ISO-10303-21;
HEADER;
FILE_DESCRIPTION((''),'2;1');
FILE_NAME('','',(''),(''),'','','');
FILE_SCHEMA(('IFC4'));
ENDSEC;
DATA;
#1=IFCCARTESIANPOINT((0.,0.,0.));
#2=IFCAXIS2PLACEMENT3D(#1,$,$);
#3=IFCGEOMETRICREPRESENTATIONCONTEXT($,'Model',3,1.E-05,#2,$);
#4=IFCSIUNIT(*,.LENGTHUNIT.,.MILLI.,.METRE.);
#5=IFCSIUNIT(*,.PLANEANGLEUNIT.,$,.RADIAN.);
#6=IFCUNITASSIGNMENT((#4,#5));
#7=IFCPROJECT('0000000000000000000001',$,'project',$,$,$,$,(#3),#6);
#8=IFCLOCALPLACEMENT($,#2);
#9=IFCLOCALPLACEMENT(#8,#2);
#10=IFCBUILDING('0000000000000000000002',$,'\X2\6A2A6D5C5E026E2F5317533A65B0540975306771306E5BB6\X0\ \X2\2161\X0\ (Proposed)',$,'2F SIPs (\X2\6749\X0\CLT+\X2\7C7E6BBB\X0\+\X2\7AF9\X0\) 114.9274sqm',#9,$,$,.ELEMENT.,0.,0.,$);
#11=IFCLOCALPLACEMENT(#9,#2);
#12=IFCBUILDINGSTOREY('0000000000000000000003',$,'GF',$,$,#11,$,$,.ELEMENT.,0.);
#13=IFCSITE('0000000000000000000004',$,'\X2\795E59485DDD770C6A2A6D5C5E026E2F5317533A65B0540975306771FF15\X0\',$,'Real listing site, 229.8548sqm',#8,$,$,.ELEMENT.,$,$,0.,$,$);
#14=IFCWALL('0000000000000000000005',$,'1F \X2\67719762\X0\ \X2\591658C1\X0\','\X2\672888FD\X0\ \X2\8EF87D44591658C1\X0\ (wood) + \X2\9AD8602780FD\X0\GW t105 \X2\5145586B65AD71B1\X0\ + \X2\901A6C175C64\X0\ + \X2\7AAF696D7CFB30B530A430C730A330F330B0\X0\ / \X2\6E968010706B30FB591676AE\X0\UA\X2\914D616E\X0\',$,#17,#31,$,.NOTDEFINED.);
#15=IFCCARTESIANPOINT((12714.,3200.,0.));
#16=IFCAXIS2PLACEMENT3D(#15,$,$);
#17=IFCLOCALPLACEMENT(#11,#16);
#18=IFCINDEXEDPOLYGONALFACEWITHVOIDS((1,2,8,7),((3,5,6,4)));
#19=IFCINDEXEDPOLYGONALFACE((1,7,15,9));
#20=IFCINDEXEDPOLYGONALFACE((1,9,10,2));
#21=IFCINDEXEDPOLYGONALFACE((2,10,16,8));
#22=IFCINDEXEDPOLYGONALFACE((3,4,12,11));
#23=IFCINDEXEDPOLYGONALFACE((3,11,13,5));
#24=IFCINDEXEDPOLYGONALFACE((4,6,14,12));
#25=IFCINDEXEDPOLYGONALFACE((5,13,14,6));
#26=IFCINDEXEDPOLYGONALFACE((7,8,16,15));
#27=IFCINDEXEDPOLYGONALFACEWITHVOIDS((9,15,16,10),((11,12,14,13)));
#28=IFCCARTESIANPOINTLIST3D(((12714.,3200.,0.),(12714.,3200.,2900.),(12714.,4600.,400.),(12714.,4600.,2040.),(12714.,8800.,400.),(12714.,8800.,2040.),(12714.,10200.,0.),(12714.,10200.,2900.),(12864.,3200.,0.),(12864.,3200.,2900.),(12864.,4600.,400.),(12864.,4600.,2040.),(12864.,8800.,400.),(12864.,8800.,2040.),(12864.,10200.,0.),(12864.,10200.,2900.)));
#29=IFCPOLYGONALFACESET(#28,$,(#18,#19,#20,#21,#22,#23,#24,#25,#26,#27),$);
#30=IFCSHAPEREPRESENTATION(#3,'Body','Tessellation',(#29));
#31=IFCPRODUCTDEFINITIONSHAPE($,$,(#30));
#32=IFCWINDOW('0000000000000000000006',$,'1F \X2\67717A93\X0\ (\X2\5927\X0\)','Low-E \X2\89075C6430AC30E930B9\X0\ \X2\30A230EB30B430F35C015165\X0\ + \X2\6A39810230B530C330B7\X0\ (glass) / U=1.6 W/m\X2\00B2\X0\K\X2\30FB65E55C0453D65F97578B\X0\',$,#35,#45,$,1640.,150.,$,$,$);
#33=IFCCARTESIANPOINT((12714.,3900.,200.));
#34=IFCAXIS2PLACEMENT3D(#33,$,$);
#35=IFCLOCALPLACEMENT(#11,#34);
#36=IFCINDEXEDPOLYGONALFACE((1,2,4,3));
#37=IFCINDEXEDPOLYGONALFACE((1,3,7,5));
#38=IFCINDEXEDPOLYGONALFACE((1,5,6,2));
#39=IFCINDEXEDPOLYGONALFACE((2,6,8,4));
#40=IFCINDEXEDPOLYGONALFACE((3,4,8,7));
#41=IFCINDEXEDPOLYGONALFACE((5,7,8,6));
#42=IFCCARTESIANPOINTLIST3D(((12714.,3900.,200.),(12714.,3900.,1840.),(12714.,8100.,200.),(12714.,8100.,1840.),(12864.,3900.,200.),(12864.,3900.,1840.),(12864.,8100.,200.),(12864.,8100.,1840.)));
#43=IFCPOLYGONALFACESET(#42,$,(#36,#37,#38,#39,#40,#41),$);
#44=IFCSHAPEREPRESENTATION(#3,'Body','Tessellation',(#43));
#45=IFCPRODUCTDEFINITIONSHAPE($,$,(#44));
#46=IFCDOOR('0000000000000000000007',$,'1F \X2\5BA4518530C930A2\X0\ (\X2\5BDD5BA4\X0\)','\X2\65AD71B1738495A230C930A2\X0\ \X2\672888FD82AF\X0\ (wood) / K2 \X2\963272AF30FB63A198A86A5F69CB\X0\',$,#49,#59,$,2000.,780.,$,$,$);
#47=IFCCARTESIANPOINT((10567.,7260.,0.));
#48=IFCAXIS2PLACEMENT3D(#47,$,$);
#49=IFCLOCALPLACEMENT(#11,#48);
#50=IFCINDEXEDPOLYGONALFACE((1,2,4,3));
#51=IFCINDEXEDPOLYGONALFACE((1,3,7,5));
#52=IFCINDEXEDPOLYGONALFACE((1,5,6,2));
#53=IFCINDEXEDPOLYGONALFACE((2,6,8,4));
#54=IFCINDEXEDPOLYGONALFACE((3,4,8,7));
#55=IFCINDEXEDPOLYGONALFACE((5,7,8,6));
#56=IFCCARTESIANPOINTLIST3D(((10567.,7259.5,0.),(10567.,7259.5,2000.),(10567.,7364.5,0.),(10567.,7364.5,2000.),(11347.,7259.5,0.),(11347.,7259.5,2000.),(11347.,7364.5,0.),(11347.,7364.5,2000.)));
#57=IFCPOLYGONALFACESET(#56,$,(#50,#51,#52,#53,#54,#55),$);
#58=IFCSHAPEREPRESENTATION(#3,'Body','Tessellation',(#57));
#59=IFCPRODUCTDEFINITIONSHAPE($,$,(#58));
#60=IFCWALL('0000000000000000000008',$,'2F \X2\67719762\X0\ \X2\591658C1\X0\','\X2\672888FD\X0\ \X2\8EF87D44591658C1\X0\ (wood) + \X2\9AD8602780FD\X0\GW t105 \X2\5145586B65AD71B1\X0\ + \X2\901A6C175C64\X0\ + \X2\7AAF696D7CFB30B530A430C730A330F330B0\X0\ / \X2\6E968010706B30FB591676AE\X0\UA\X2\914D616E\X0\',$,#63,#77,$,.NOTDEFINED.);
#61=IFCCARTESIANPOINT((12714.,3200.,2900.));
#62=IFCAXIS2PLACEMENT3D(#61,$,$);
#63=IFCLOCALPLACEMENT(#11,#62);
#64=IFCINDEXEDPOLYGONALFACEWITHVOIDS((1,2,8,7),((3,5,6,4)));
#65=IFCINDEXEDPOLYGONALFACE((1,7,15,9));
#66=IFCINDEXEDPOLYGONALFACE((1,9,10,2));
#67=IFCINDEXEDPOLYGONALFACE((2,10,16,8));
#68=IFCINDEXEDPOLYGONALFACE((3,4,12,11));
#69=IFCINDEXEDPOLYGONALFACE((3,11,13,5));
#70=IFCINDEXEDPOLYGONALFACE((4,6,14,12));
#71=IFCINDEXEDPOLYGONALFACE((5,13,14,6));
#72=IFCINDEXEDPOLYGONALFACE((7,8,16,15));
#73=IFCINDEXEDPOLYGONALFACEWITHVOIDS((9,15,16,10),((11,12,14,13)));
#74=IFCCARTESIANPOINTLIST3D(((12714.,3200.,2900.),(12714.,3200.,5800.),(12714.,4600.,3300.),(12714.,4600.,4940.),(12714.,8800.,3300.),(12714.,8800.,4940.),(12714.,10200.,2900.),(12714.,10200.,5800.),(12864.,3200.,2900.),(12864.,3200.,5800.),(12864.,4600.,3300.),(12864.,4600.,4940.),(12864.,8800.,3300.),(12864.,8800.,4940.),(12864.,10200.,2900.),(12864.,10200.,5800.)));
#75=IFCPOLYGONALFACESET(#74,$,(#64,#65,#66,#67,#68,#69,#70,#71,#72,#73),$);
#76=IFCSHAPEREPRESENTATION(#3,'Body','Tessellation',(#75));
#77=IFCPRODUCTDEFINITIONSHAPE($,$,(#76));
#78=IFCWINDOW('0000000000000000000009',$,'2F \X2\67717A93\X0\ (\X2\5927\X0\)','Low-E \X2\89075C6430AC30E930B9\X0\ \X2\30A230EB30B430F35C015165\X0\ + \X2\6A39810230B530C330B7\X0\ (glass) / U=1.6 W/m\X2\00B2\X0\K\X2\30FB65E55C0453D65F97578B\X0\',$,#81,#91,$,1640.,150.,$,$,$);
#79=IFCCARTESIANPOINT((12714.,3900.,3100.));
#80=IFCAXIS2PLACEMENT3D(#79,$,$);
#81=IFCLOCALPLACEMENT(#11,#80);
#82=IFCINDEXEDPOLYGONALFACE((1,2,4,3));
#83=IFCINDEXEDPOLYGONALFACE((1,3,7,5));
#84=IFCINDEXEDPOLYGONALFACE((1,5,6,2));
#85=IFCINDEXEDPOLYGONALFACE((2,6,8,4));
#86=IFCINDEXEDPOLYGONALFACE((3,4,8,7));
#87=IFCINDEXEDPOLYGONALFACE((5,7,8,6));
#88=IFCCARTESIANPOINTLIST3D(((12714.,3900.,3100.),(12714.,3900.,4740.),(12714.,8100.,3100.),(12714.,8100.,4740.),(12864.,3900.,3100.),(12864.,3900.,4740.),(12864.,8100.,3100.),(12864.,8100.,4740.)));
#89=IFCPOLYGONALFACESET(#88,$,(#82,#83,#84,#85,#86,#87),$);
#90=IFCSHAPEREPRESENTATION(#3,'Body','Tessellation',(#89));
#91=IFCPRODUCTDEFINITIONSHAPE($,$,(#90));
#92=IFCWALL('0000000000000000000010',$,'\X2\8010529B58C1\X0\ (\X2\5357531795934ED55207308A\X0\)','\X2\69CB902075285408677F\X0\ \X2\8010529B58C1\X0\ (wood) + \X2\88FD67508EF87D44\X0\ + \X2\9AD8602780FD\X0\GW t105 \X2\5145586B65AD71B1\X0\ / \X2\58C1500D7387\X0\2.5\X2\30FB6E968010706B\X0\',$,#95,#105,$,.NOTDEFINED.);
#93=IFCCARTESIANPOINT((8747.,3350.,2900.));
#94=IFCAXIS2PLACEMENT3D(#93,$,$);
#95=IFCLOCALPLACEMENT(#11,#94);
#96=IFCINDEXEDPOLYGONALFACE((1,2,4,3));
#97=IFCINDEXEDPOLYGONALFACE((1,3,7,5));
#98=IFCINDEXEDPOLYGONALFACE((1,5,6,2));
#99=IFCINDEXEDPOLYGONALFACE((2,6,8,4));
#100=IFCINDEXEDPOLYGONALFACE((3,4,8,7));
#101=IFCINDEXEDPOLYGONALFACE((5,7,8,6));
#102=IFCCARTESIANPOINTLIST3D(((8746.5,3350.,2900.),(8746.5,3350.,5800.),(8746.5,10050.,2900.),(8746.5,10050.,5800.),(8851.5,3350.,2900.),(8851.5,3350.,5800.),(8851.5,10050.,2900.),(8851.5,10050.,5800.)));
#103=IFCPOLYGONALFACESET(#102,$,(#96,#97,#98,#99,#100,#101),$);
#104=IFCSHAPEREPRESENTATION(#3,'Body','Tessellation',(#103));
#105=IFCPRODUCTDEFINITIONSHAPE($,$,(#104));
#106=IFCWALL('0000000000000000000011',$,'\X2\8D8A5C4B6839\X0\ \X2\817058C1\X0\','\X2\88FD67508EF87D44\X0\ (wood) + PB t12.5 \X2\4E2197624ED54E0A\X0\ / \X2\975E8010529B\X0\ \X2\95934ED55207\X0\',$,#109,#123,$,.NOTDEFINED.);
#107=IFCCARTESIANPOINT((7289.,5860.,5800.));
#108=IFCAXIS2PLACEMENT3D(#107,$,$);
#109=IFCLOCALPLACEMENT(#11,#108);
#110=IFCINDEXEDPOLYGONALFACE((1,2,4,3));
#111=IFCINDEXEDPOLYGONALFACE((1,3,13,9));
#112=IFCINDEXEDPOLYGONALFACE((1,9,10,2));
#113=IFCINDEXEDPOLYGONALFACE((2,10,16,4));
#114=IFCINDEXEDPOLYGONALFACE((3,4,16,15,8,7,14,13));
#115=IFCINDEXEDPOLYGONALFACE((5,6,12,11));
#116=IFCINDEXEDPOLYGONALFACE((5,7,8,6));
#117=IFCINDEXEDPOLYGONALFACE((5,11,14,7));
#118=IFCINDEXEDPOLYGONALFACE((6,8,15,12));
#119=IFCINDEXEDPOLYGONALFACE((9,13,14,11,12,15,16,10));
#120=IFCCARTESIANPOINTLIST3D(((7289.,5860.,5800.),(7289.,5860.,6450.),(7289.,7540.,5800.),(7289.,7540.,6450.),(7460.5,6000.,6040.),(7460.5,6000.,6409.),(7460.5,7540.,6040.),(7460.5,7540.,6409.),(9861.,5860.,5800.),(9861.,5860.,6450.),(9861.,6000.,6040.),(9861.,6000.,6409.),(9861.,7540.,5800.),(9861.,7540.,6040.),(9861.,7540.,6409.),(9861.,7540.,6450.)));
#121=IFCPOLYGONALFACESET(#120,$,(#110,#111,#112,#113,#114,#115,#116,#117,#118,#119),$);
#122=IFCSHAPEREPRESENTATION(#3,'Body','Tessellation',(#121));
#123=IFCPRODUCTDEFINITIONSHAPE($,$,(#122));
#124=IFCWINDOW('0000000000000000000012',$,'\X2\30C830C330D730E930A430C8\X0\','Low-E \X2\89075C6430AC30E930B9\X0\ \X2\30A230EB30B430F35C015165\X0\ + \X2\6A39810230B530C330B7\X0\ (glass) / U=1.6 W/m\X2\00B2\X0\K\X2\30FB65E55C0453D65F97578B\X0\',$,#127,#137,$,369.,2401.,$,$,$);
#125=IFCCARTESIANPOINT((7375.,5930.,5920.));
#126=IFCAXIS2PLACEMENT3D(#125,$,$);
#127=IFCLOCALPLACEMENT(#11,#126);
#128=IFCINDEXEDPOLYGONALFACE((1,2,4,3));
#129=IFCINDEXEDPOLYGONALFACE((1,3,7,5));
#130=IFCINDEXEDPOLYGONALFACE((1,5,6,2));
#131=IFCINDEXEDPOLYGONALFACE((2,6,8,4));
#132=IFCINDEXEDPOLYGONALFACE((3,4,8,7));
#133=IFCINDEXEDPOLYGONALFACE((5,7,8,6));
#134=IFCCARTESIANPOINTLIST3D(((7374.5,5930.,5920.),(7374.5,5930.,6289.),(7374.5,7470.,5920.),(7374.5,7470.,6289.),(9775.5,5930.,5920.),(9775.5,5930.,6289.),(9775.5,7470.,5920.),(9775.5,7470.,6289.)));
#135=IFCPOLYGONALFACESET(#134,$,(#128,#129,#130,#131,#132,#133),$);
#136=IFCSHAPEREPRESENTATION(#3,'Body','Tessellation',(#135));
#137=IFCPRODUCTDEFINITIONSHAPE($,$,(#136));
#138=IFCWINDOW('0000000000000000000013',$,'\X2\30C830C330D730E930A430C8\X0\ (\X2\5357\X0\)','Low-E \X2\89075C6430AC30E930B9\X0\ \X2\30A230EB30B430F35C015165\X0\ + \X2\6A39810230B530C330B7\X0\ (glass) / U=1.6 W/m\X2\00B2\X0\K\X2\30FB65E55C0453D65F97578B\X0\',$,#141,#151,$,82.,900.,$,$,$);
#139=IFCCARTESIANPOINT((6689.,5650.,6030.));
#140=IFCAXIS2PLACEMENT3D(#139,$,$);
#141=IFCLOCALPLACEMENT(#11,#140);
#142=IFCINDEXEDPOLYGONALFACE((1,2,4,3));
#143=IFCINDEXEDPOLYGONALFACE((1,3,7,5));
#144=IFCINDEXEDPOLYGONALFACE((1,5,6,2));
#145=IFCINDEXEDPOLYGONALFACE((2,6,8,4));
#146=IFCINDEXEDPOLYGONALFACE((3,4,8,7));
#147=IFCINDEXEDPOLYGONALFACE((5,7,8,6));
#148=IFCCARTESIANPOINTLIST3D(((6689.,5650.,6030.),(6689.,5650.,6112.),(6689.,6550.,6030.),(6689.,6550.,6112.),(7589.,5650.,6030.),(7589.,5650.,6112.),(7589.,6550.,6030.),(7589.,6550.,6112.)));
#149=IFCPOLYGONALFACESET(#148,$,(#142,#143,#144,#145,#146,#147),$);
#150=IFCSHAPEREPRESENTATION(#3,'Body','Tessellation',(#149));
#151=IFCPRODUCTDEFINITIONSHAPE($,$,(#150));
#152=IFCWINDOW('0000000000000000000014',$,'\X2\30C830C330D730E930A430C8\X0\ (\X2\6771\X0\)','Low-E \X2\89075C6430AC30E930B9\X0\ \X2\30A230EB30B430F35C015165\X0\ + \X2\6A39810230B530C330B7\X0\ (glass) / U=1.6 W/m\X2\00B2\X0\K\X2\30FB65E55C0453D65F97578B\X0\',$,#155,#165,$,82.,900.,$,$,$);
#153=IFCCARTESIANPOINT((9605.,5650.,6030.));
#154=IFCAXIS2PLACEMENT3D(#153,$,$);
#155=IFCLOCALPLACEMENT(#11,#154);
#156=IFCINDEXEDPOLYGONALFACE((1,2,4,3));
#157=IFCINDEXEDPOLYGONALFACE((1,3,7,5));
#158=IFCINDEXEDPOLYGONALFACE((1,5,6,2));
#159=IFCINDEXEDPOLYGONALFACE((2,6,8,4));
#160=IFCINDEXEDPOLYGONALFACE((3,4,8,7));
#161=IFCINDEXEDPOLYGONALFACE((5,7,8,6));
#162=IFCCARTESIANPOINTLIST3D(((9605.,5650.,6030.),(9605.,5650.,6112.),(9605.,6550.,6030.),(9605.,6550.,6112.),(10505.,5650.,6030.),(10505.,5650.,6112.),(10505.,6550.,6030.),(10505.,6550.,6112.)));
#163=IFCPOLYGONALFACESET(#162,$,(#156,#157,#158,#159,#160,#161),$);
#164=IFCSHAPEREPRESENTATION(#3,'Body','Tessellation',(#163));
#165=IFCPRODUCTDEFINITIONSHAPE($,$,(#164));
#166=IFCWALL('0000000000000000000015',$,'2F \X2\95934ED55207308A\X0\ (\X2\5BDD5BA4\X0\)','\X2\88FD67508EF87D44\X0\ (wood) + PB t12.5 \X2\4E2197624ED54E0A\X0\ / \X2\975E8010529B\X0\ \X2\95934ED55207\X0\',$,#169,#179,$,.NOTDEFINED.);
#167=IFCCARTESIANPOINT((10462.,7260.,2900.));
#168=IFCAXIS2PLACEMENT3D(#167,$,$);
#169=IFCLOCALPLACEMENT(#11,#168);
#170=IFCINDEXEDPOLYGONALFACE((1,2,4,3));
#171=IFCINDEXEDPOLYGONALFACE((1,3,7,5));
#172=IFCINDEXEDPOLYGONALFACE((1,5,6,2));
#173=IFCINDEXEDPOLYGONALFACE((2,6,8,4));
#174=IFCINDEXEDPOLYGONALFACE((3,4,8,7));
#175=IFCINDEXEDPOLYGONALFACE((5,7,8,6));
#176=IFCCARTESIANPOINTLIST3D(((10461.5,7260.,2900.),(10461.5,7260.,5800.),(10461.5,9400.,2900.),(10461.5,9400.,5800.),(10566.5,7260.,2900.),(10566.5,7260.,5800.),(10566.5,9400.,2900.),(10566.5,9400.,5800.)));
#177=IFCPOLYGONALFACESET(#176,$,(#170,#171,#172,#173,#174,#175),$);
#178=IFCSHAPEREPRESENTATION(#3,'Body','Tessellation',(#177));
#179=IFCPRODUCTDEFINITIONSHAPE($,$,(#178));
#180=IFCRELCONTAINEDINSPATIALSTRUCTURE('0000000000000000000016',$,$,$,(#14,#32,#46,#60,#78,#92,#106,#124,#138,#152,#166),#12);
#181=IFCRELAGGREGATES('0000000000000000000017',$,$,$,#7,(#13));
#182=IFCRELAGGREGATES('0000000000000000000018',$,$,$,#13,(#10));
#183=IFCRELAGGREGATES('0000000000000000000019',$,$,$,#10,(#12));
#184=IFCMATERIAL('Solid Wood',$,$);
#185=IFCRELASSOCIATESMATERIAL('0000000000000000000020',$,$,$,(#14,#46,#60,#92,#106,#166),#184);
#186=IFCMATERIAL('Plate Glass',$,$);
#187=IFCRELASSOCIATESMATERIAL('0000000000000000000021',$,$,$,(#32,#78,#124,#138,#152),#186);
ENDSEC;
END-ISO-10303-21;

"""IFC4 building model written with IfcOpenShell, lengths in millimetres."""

from ifc_helpers import new_model, si_unit, frame, frame_2d, origin, place, context, project, spatial, rectangle, extrude, material, element, fill, save


model = new_model("IFC4")

# Units and contexts
model_context = context("Model", 3, precision=1e-05, world=origin())
ifc_project = project(units=[si_unit("LENGTHUNIT", "METRE", prefix="MILLI"), si_unit("PLANEANGLEUNIT", "RADIAN")], contexts=[model_context])

# Site, building, storey
site_placement = place(None, origin())
site = spatial("IfcSite", under=ifc_project, at=site_placement, Name="神奈川県横浜市港北区新吉田東５", ObjectType="Real listing site, 229.8548sqm", CompositionType="ELEMENT", RefElevation=0.0)
building_placement = place(site_placement, origin())
building = spatial("IfcBuilding", under=site, at=building_placement, Name="横浜市港北区新吉田東の家 Ⅱ (Proposed)", ObjectType="2F SIPs (杉CLT+籾殻+竹) 114.9274sqm", CompositionType="ELEMENT", ElevationOfRefHeight=0.0, ElevationOfTerrain=0.0)
storey_placement = place(building_placement, origin())
storey = spatial("IfcBuildingStorey", under=building, at=storey_placement, Name="GF", CompositionType="ELEMENT", Elevation=0.0)

# Wall, opening, window
ifc_material_1 = material(Name="Solid Wood")
wall_1_placement = place(storey_placement, frame((12714.0, 3200.0, 0.0)))
wall_1 = element("IfcWall", 1, at=wall_1_placement, inside=storey, material=ifc_material_1, Name="1F 東面 外壁", Description="木製 軸組外壁 (wood) + 高性能GW t105 充填断熱 + 通気層 + 窯業系サイディング / 準耐火・外皮UA配慮", PredefinedType="NOTDEFINED", context=model_context, shape_type="SweptSolid", body=[
    extrude(rectangle(XDim=150.0, YDim=7000.0, at=frame_2d((75.0, 3500.0))), frame((12714.0, 3200.0, 0.0)), (0.0, 0.0, 1.0), 2900.0),
])
opening_1_placement = place(storey_placement, frame((12714.0, 3900.0, 200.0)))
opening_1 = element("IfcOpeningElement", 2, at=opening_1_placement, cuts=wall_1, PredefinedType="NOTDEFINED", context=model_context, shape_type="SweptSolid", body=[
    extrude(rectangle(XDim=150.0, YDim=4200.0, at=frame_2d((75.0, 2100.0))), frame((12714.0, 3900.0, 200.0)), (0.0, 0.0, 1.0), 1640.0),
])
ifc_material_2 = material(Name="Plate Glass")
window_1_placement = place(storey_placement, frame((12714.0, 3900.0, 200.0)))
window_1 = element("IfcWindow", 3, at=window_1_placement, inside=storey, material=ifc_material_2, Name="1F 東窓 (大)", Description="Low-E 複層ガラス アルゴン封入 + 樹脂サッシ (glass) / U=1.6 W/m²K・日射取得型", OverallHeight=1640.0, OverallWidth=150.0, context=model_context, shape_type="SweptSolid", body=[
    extrude(rectangle(XDim=150.0, YDim=4200.0, at=frame_2d((75.0, 2100.0))), frame((12714.0, 3900.0, 200.0)), (0.0, 0.0, 1.0), 1640.0),
])
fill(opening_1, window_1)

# Door
door_1_placement = place(storey_placement, frame((10567.0, 7260.0, 0.0)))
element("IfcDoor", 4, at=door_1_placement, inside=storey, material=ifc_material_1, Name="1F 室内ドア (寝室)", Description="断熱玄関ドア 木製芯 (wood) / K2 防犯・採風機構", OverallHeight=2000.0, OverallWidth=780.0, context=model_context, shape_type="SweptSolid", body=[
    extrude(rectangle(XDim=780.0, YDim=105.0, at=frame_2d((390.0, 52.0))), frame((10567.0, 7260.0, 0.0)), (0.0, 0.0, 1.0), 2000.0),
])

# Wall, opening, window
wall_2_placement = place(storey_placement, frame((12714.0, 3200.0, 2900.0)))
wall_2 = element("IfcWall", 5, at=wall_2_placement, inside=storey, material=ifc_material_1, Name="2F 東面 外壁", Description="木製 軸組外壁 (wood) + 高性能GW t105 充填断熱 + 通気層 + 窯業系サイディング / 準耐火・外皮UA配慮", PredefinedType="NOTDEFINED", context=model_context, shape_type="SweptSolid", body=[
    extrude(rectangle(XDim=150.0, YDim=7000.0, at=frame_2d((75.0, 3500.0))), frame((12714.0, 3200.0, 2900.0)), (0.0, 0.0, 1.0), 2900.0),
])
opening_2_placement = place(storey_placement, frame((12714.0, 3900.0, 3100.0)))
opening_2 = element("IfcOpeningElement", 6, at=opening_2_placement, cuts=wall_2, PredefinedType="NOTDEFINED", context=model_context, shape_type="SweptSolid", body=[
    extrude(rectangle(XDim=150.0, YDim=4200.0, at=frame_2d((75.0, 2100.0))), frame((12714.0, 3900.0, 3100.0)), (0.0, 0.0, 1.0), 1640.0),
])
window_2_placement = place(storey_placement, frame((12714.0, 3900.0, 3100.0)))
window_2 = element("IfcWindow", 7, at=window_2_placement, inside=storey, material=ifc_material_2, Name="2F 東窓 (大)", Description="Low-E 複層ガラス アルゴン封入 + 樹脂サッシ (glass) / U=1.6 W/m²K・日射取得型", OverallHeight=1640.0, OverallWidth=150.0, context=model_context, shape_type="SweptSolid", body=[
    extrude(rectangle(XDim=150.0, YDim=4200.0, at=frame_2d((75.0, 2100.0))), frame((12714.0, 3900.0, 3100.0)), (0.0, 0.0, 1.0), 1640.0),
])
fill(opening_2, window_2)

# Wall
wall_3_placement = place(storey_placement, frame((8747.0, 3350.0, 2900.0)))
element("IfcWall", 8, at=wall_3_placement, inside=storey, material=ifc_material_1, Name="耐力壁 (南北間仕切り)", Description="構造用合板 耐力壁 (wood) + 製材軸組 + 高性能GW t105 充填断熱 / 壁倍率2.5・準耐火", PredefinedType="NOTDEFINED", context=model_context, shape_type="SweptSolid", body=[
    extrude(rectangle(XDim=105.0, YDim=6700.0, at=frame_2d((52.0, 3350.0))), frame((8747.0, 3350.0, 2900.0)), (0.0, 0.0, 1.0), 2900.0),
])

# Wall, openings, windows
wall_4_placement = place(storey_placement, frame((7289.0, 5860.0, 5800.0)))
wall_4 = element("IfcWall", 9, at=wall_4_placement, inside=storey, material=ifc_material_1, Name="越屋根 腰壁", Description="製材軸組 (wood) + PB t12.5 両面仕上 / 非耐力 間仕切", PredefinedType="NOTDEFINED", context=model_context, shape_type="SweptSolid", body=[
    extrude(rectangle(XDim=2572.0, YDim=1680.0, at=frame_2d((1286.0, 840.0))), frame((7289.0, 5860.0, 5800.0)), (0.0, 0.0, 1.0), 650.0),
])
opening_3_placement = place(storey_placement, frame((7375.0, 5930.0, 5920.0)))
opening_3 = element("IfcOpeningElement", 10, at=opening_3_placement, cuts=wall_4, PredefinedType="NOTDEFINED", context=model_context, shape_type="SweptSolid", body=[
    extrude(rectangle(XDim=2401.0, YDim=1540.0, at=frame_2d((1200.0, 770.0))), frame((7375.0, 5930.0, 5920.0)), (0.0, 0.0, 1.0), 369.0),
])
opening_4_placement = place(storey_placement, frame((6689.0, 5650.0, 6030.0)))
opening_4 = element("IfcOpeningElement", 11, at=opening_4_placement, cuts=wall_4, PredefinedType="NOTDEFINED", context=model_context, shape_type="SweptSolid", body=[
    extrude(rectangle(XDim=900.0, YDim=900.0, at=frame_2d((450.0, 450.0))), frame((6689.0, 5650.0, 6030.0)), (0.0, 0.0, 1.0), 82.0),
])
opening_5_placement = place(storey_placement, frame((9605.0, 5650.0, 6030.0)))
opening_5 = element("IfcOpeningElement", 12, at=opening_5_placement, cuts=wall_4, PredefinedType="NOTDEFINED", context=model_context, shape_type="SweptSolid", body=[
    extrude(rectangle(XDim=900.0, YDim=900.0, at=frame_2d((450.0, 450.0))), frame((9605.0, 5650.0, 6030.0)), (0.0, 0.0, 1.0), 82.0),
])
window_3_placement = place(storey_placement, frame((7375.0, 5930.0, 5920.0)))
window_3 = element("IfcWindow", 13, at=window_3_placement, inside=storey, material=ifc_material_2, Name="トップライト", Description="Low-E 複層ガラス アルゴン封入 + 樹脂サッシ (glass) / U=1.6 W/m²K・日射取得型", OverallHeight=369.0, OverallWidth=2401.0, context=model_context, shape_type="SweptSolid", body=[
    extrude(rectangle(XDim=2401.0, YDim=1540.0, at=frame_2d((1200.0, 770.0))), frame((7375.0, 5930.0, 5920.0)), (0.0, 0.0, 1.0), 369.0),
])
fill(opening_3, window_3)
window_4_placement = place(storey_placement, frame((6689.0, 5650.0, 6030.0)))
window_4 = element("IfcWindow", 14, at=window_4_placement, inside=storey, material=ifc_material_2, Name="トップライト (南)", Description="Low-E 複層ガラス アルゴン封入 + 樹脂サッシ (glass) / U=1.6 W/m²K・日射取得型", OverallHeight=82.0, OverallWidth=900.0, context=model_context, shape_type="SweptSolid", body=[
    extrude(rectangle(XDim=900.0, YDim=900.0, at=frame_2d((450.0, 450.0))), frame((6689.0, 5650.0, 6030.0)), (0.0, 0.0, 1.0), 82.0),
])
fill(opening_4, window_4)
window_5_placement = place(storey_placement, frame((9605.0, 5650.0, 6030.0)))
window_5 = element("IfcWindow", 15, at=window_5_placement, inside=storey, material=ifc_material_2, Name="トップライト (東)", Description="Low-E 複層ガラス アルゴン封入 + 樹脂サッシ (glass) / U=1.6 W/m²K・日射取得型", OverallHeight=82.0, OverallWidth=900.0, context=model_context, shape_type="SweptSolid", body=[
    extrude(rectangle(XDim=900.0, YDim=900.0, at=frame_2d((450.0, 450.0))), frame((9605.0, 5650.0, 6030.0)), (0.0, 0.0, 1.0), 82.0),
])
fill(opening_5, window_5)

# Wall
wall_5_placement = place(storey_placement, frame((10462.0, 7260.0, 2900.0)))
element("IfcWall", 16, at=wall_5_placement, inside=storey, material=ifc_material_1, Name="2F 間仕切り (寝室)", Description="製材軸組 (wood) + PB t12.5 両面仕上 / 非耐力 間仕切", PredefinedType="NOTDEFINED", context=model_context, shape_type="SweptSolid", body=[
    extrude(rectangle(XDim=105.0, YDim=2140.0, at=frame_2d((52.0, 1070.0))), frame((10462.0, 7260.0, 2900.0)), (0.0, 0.0, 1.0), 2900.0),
])

save(model, "model.ifc")
